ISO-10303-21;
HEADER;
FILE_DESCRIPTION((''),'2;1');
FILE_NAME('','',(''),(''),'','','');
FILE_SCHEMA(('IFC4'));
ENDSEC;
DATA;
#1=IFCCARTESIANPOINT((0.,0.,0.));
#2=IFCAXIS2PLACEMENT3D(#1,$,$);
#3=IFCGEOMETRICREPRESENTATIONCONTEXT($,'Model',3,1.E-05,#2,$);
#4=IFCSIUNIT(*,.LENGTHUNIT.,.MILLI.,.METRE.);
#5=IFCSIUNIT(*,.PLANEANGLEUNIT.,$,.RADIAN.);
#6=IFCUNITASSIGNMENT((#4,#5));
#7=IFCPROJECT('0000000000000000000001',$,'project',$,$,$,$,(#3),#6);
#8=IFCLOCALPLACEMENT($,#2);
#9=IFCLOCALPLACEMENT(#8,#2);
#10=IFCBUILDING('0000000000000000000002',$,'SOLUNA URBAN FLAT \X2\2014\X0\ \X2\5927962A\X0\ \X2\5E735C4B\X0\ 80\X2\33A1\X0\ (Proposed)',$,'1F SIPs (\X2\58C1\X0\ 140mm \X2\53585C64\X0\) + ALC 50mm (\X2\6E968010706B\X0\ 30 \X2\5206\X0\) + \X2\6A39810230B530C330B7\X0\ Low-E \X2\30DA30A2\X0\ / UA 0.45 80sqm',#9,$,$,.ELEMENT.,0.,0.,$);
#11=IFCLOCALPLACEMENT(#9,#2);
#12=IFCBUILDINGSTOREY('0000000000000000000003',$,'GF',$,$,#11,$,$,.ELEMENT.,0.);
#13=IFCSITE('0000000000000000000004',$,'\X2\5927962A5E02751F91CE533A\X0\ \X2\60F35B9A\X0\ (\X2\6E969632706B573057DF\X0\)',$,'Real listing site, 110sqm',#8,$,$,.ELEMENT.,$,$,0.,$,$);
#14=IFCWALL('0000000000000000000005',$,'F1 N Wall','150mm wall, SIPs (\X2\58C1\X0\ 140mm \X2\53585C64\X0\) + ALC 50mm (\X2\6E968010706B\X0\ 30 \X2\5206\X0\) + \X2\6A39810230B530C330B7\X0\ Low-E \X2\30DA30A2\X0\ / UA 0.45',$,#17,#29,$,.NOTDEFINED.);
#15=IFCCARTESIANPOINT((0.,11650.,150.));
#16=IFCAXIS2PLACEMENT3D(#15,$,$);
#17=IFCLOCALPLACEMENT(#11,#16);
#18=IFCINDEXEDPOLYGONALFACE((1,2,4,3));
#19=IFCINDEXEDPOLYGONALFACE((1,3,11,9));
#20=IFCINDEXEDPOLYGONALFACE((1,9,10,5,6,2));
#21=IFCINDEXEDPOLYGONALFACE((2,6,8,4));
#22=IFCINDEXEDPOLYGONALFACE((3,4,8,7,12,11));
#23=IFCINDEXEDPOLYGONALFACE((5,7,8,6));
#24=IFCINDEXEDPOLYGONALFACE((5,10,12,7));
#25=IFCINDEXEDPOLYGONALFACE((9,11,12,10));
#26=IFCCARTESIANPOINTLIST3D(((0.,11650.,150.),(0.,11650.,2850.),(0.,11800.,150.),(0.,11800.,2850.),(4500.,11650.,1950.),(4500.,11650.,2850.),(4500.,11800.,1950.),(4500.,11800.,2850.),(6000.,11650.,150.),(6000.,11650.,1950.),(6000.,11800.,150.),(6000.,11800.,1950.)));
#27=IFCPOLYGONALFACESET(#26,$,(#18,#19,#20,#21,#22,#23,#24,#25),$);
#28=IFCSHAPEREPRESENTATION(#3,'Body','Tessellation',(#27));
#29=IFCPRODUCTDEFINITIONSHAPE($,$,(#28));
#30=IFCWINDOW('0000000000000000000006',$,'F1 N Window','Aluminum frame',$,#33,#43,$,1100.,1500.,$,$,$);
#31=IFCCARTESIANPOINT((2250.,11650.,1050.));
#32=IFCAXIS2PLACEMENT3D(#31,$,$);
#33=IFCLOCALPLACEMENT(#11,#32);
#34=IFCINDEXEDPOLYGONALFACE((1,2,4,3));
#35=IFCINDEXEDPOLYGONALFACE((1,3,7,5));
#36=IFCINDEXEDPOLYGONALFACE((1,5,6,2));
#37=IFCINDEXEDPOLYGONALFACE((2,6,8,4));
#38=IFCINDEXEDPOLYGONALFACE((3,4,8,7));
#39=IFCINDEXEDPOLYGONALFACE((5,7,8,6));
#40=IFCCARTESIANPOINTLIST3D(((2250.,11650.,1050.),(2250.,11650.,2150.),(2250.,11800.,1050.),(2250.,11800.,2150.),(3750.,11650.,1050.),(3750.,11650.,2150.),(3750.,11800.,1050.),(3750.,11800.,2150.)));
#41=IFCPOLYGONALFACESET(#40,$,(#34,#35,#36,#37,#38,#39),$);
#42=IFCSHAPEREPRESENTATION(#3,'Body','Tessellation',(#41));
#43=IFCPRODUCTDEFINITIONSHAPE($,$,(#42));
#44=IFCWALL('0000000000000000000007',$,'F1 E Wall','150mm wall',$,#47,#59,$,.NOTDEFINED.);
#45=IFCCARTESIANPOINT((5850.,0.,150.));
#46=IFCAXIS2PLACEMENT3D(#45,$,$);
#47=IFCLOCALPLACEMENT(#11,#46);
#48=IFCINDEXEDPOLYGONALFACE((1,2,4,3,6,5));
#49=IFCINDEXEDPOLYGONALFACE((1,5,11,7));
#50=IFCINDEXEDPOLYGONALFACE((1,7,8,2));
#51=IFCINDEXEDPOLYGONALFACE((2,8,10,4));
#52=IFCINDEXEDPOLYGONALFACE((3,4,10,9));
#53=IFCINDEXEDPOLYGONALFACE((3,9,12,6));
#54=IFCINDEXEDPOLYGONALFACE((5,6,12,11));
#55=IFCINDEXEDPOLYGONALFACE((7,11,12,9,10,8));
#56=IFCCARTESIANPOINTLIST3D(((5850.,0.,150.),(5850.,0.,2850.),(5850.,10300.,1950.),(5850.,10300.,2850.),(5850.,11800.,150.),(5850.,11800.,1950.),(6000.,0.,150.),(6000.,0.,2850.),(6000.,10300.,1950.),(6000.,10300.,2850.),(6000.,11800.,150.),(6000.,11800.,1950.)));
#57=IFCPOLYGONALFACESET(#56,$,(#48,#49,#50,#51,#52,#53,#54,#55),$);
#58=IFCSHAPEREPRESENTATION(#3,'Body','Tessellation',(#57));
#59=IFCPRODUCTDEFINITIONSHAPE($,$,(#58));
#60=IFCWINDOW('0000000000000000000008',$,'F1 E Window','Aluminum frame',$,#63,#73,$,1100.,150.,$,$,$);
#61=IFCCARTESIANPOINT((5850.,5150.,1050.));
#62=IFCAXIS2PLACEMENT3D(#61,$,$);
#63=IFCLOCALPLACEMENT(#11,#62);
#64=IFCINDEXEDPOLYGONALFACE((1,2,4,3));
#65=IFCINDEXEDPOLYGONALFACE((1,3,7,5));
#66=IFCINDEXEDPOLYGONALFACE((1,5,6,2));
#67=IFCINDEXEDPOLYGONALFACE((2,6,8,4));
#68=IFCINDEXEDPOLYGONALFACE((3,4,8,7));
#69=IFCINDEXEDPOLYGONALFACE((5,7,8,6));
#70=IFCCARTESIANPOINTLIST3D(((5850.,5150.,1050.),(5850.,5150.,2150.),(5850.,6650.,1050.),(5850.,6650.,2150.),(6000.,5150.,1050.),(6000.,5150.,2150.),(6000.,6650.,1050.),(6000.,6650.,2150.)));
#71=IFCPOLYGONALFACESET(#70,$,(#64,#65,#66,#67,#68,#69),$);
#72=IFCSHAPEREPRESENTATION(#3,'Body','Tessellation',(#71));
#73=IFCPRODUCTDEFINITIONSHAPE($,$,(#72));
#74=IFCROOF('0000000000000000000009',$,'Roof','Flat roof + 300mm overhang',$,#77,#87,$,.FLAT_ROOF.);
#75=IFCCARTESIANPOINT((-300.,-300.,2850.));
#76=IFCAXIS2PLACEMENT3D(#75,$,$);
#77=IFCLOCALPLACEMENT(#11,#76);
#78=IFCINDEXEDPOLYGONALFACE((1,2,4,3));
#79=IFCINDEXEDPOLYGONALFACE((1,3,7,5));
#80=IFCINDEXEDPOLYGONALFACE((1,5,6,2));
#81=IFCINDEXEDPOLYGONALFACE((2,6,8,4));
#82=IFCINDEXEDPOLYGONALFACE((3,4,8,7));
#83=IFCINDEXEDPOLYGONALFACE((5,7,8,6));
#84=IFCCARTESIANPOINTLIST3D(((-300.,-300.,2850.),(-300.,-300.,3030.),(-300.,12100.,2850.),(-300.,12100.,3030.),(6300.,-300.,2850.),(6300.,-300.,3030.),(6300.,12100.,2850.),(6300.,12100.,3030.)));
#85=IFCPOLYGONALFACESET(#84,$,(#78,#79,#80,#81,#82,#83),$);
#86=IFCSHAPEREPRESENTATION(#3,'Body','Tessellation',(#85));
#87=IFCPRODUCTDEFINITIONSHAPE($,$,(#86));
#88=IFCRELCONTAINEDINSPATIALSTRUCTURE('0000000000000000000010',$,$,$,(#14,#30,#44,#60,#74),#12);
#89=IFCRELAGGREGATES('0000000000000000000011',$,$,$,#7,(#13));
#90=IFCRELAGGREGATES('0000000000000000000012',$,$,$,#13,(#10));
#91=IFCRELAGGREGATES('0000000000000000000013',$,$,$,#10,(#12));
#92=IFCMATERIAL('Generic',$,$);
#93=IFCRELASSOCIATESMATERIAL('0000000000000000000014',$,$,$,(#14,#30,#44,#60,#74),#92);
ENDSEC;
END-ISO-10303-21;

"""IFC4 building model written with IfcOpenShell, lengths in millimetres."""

from ifc_helpers import new_model, si_unit, frame, frame_2d, origin, place, context, project, spatial, rectangle, extrude, material, element, fill, save


model = new_model("IFC4")

# Units and contexts
model_context = context("Model", 3, precision=1e-05, world=origin())
ifc_project = project(units=[si_unit("LENGTHUNIT", "METRE", prefix="MILLI"), si_unit("PLANEANGLEUNIT", "RADIAN")], contexts=[model_context])

# Site, building, storey
site_placement = place(None, origin())
site = spatial("IfcSite", under=ifc_project, at=site_placement, Name="大阪市生野区 想定 (準防火地域)", ObjectType="Real listing site, 110sqm", CompositionType="ELEMENT", RefElevation=0.0)
building_placement = place(site_placement, origin())
building = spatial("IfcBuilding", under=site, at=building_placement, Name="SOLUNA URBAN FLAT — 大阪 平屋 80㎡ (Proposed)", ObjectType="1F SIPs (壁 140mm 単層) + ALC 50mm (準耐火 30 分) + 樹脂サッシ Low-E ペア / UA 0.45 80sqm", CompositionType="ELEMENT", ElevationOfRefHeight=0.0, ElevationOfTerrain=0.0)
storey_placement = place(building_placement, origin())
storey = spatial("IfcBuildingStorey", under=building, at=storey_placement, Name="GF", CompositionType="ELEMENT", Elevation=0.0)

# Wall, opening, window
ifc_material_1 = material(Name="Generic")
wall_1_placement = place(storey_placement, frame((0.0, 11650.0, 150.0)))
wall_1 = element("IfcWall", 1, at=wall_1_placement, inside=storey, material=ifc_material_1, Name="F1 N Wall", Description="150mm wall, SIPs (壁 140mm 単層) + ALC 50mm (準耐火 30 分) + 樹脂サッシ Low-E ペア / UA 0.45", PredefinedType="NOTDEFINED", context=model_context, shape_type="SweptSolid", body=[
    extrude(rectangle(XDim=6000.0, YDim=150.0, at=frame_2d((3000.0, 75.0))), frame((0.0, 11650.0, 150.0)), (0.0, 0.0, 1.0), 2700.0),
])
opening_1_placement = place(storey_placement, frame((2250.0, 11650.0, 1050.0)))
opening_1 = element("IfcOpeningElement", 2, at=opening_1_placement, cuts=wall_1, PredefinedType="NOTDEFINED", context=model_context, shape_type="SweptSolid", body=[
    extrude(rectangle(XDim=1500.0, YDim=150.0, at=frame_2d((750.0, 75.0))), frame((2250.0, 11650.0, 1050.0)), (0.0, 0.0, 1.0), 1100.0),
])
window_1_placement = place(storey_placement, frame((2250.0, 11650.0, 1050.0)))
window_1 = element("IfcWindow", 3, at=window_1_placement, inside=storey, material=ifc_material_1, Name="F1 N Window", Description="Aluminum frame", OverallHeight=1100.0, OverallWidth=1500.0, context=model_context, shape_type="SweptSolid", body=[
    extrude(rectangle(XDim=1500.0, YDim=150.0, at=frame_2d((750.0, 75.0))), frame((2250.0, 11650.0, 1050.0)), (0.0, 0.0, 1.0), 1100.0),
])
fill(opening_1, window_1)

# Wall, opening, window
wall_2_placement = place(storey_placement, frame((5850.0, 0.0, 150.0)))
wall_2 = element("IfcWall", 4, at=wall_2_placement, inside=storey, material=ifc_material_1, Name="F1 E Wall", Description="150mm wall", PredefinedType="NOTDEFINED", context=model_context, shape_type="SweptSolid", body=[
    extrude(rectangle(XDim=150.0, YDim=11800.0, at=frame_2d((75.0, 5900.0))), frame((5850.0, 0.0, 150.0)), (0.0, 0.0, 1.0), 2700.0),
])
opening_2_placement = place(storey_placement, frame((5850.0, 5150.0, 1050.0)))
opening_2 = element("IfcOpeningElement", 5, at=opening_2_placement, cuts=wall_2, PredefinedType="NOTDEFINED", context=model_context, shape_type="SweptSolid", body=[
    extrude(rectangle(XDim=150.0, YDim=1500.0, at=frame_2d((75.0, 750.0))), frame((5850.0, 5150.0, 1050.0)), (0.0, 0.0, 1.0), 1100.0),
])
window_2_placement = place(storey_placement, frame((5850.0, 5150.0, 1050.0)))
window_2 = element("IfcWindow", 6, at=window_2_placement, inside=storey, material=ifc_material_1, Name="F1 E Window", Description="Aluminum frame", OverallHeight=1100.0, OverallWidth=150.0, context=model_context, shape_type="SweptSolid", body=[
    extrude(rectangle(XDim=150.0, YDim=1500.0, at=frame_2d((75.0, 750.0))), frame((5850.0, 5150.0, 1050.0)), (0.0, 0.0, 1.0), 1100.0),
])
fill(opening_2, window_2)

# Roof
roof_placement = place(storey_placement, frame((-300.0, -300.0, 2850.0)))
element("IfcRoof", 7, at=roof_placement, inside=storey, material=ifc_material_1, Name="Roof", Description="Flat roof + 300mm overhang", PredefinedType="FLAT_ROOF", context=model_context, shape_type="SweptSolid", body=[
    extrude(rectangle(XDim=6600.0, YDim=12400.0, at=frame_2d((3300.0, 6200.0))), frame((-300.0, -300.0, 2850.0)), (0.0, 0.0, 1.0), 180.0),
])

save(model, "model.ifc")
